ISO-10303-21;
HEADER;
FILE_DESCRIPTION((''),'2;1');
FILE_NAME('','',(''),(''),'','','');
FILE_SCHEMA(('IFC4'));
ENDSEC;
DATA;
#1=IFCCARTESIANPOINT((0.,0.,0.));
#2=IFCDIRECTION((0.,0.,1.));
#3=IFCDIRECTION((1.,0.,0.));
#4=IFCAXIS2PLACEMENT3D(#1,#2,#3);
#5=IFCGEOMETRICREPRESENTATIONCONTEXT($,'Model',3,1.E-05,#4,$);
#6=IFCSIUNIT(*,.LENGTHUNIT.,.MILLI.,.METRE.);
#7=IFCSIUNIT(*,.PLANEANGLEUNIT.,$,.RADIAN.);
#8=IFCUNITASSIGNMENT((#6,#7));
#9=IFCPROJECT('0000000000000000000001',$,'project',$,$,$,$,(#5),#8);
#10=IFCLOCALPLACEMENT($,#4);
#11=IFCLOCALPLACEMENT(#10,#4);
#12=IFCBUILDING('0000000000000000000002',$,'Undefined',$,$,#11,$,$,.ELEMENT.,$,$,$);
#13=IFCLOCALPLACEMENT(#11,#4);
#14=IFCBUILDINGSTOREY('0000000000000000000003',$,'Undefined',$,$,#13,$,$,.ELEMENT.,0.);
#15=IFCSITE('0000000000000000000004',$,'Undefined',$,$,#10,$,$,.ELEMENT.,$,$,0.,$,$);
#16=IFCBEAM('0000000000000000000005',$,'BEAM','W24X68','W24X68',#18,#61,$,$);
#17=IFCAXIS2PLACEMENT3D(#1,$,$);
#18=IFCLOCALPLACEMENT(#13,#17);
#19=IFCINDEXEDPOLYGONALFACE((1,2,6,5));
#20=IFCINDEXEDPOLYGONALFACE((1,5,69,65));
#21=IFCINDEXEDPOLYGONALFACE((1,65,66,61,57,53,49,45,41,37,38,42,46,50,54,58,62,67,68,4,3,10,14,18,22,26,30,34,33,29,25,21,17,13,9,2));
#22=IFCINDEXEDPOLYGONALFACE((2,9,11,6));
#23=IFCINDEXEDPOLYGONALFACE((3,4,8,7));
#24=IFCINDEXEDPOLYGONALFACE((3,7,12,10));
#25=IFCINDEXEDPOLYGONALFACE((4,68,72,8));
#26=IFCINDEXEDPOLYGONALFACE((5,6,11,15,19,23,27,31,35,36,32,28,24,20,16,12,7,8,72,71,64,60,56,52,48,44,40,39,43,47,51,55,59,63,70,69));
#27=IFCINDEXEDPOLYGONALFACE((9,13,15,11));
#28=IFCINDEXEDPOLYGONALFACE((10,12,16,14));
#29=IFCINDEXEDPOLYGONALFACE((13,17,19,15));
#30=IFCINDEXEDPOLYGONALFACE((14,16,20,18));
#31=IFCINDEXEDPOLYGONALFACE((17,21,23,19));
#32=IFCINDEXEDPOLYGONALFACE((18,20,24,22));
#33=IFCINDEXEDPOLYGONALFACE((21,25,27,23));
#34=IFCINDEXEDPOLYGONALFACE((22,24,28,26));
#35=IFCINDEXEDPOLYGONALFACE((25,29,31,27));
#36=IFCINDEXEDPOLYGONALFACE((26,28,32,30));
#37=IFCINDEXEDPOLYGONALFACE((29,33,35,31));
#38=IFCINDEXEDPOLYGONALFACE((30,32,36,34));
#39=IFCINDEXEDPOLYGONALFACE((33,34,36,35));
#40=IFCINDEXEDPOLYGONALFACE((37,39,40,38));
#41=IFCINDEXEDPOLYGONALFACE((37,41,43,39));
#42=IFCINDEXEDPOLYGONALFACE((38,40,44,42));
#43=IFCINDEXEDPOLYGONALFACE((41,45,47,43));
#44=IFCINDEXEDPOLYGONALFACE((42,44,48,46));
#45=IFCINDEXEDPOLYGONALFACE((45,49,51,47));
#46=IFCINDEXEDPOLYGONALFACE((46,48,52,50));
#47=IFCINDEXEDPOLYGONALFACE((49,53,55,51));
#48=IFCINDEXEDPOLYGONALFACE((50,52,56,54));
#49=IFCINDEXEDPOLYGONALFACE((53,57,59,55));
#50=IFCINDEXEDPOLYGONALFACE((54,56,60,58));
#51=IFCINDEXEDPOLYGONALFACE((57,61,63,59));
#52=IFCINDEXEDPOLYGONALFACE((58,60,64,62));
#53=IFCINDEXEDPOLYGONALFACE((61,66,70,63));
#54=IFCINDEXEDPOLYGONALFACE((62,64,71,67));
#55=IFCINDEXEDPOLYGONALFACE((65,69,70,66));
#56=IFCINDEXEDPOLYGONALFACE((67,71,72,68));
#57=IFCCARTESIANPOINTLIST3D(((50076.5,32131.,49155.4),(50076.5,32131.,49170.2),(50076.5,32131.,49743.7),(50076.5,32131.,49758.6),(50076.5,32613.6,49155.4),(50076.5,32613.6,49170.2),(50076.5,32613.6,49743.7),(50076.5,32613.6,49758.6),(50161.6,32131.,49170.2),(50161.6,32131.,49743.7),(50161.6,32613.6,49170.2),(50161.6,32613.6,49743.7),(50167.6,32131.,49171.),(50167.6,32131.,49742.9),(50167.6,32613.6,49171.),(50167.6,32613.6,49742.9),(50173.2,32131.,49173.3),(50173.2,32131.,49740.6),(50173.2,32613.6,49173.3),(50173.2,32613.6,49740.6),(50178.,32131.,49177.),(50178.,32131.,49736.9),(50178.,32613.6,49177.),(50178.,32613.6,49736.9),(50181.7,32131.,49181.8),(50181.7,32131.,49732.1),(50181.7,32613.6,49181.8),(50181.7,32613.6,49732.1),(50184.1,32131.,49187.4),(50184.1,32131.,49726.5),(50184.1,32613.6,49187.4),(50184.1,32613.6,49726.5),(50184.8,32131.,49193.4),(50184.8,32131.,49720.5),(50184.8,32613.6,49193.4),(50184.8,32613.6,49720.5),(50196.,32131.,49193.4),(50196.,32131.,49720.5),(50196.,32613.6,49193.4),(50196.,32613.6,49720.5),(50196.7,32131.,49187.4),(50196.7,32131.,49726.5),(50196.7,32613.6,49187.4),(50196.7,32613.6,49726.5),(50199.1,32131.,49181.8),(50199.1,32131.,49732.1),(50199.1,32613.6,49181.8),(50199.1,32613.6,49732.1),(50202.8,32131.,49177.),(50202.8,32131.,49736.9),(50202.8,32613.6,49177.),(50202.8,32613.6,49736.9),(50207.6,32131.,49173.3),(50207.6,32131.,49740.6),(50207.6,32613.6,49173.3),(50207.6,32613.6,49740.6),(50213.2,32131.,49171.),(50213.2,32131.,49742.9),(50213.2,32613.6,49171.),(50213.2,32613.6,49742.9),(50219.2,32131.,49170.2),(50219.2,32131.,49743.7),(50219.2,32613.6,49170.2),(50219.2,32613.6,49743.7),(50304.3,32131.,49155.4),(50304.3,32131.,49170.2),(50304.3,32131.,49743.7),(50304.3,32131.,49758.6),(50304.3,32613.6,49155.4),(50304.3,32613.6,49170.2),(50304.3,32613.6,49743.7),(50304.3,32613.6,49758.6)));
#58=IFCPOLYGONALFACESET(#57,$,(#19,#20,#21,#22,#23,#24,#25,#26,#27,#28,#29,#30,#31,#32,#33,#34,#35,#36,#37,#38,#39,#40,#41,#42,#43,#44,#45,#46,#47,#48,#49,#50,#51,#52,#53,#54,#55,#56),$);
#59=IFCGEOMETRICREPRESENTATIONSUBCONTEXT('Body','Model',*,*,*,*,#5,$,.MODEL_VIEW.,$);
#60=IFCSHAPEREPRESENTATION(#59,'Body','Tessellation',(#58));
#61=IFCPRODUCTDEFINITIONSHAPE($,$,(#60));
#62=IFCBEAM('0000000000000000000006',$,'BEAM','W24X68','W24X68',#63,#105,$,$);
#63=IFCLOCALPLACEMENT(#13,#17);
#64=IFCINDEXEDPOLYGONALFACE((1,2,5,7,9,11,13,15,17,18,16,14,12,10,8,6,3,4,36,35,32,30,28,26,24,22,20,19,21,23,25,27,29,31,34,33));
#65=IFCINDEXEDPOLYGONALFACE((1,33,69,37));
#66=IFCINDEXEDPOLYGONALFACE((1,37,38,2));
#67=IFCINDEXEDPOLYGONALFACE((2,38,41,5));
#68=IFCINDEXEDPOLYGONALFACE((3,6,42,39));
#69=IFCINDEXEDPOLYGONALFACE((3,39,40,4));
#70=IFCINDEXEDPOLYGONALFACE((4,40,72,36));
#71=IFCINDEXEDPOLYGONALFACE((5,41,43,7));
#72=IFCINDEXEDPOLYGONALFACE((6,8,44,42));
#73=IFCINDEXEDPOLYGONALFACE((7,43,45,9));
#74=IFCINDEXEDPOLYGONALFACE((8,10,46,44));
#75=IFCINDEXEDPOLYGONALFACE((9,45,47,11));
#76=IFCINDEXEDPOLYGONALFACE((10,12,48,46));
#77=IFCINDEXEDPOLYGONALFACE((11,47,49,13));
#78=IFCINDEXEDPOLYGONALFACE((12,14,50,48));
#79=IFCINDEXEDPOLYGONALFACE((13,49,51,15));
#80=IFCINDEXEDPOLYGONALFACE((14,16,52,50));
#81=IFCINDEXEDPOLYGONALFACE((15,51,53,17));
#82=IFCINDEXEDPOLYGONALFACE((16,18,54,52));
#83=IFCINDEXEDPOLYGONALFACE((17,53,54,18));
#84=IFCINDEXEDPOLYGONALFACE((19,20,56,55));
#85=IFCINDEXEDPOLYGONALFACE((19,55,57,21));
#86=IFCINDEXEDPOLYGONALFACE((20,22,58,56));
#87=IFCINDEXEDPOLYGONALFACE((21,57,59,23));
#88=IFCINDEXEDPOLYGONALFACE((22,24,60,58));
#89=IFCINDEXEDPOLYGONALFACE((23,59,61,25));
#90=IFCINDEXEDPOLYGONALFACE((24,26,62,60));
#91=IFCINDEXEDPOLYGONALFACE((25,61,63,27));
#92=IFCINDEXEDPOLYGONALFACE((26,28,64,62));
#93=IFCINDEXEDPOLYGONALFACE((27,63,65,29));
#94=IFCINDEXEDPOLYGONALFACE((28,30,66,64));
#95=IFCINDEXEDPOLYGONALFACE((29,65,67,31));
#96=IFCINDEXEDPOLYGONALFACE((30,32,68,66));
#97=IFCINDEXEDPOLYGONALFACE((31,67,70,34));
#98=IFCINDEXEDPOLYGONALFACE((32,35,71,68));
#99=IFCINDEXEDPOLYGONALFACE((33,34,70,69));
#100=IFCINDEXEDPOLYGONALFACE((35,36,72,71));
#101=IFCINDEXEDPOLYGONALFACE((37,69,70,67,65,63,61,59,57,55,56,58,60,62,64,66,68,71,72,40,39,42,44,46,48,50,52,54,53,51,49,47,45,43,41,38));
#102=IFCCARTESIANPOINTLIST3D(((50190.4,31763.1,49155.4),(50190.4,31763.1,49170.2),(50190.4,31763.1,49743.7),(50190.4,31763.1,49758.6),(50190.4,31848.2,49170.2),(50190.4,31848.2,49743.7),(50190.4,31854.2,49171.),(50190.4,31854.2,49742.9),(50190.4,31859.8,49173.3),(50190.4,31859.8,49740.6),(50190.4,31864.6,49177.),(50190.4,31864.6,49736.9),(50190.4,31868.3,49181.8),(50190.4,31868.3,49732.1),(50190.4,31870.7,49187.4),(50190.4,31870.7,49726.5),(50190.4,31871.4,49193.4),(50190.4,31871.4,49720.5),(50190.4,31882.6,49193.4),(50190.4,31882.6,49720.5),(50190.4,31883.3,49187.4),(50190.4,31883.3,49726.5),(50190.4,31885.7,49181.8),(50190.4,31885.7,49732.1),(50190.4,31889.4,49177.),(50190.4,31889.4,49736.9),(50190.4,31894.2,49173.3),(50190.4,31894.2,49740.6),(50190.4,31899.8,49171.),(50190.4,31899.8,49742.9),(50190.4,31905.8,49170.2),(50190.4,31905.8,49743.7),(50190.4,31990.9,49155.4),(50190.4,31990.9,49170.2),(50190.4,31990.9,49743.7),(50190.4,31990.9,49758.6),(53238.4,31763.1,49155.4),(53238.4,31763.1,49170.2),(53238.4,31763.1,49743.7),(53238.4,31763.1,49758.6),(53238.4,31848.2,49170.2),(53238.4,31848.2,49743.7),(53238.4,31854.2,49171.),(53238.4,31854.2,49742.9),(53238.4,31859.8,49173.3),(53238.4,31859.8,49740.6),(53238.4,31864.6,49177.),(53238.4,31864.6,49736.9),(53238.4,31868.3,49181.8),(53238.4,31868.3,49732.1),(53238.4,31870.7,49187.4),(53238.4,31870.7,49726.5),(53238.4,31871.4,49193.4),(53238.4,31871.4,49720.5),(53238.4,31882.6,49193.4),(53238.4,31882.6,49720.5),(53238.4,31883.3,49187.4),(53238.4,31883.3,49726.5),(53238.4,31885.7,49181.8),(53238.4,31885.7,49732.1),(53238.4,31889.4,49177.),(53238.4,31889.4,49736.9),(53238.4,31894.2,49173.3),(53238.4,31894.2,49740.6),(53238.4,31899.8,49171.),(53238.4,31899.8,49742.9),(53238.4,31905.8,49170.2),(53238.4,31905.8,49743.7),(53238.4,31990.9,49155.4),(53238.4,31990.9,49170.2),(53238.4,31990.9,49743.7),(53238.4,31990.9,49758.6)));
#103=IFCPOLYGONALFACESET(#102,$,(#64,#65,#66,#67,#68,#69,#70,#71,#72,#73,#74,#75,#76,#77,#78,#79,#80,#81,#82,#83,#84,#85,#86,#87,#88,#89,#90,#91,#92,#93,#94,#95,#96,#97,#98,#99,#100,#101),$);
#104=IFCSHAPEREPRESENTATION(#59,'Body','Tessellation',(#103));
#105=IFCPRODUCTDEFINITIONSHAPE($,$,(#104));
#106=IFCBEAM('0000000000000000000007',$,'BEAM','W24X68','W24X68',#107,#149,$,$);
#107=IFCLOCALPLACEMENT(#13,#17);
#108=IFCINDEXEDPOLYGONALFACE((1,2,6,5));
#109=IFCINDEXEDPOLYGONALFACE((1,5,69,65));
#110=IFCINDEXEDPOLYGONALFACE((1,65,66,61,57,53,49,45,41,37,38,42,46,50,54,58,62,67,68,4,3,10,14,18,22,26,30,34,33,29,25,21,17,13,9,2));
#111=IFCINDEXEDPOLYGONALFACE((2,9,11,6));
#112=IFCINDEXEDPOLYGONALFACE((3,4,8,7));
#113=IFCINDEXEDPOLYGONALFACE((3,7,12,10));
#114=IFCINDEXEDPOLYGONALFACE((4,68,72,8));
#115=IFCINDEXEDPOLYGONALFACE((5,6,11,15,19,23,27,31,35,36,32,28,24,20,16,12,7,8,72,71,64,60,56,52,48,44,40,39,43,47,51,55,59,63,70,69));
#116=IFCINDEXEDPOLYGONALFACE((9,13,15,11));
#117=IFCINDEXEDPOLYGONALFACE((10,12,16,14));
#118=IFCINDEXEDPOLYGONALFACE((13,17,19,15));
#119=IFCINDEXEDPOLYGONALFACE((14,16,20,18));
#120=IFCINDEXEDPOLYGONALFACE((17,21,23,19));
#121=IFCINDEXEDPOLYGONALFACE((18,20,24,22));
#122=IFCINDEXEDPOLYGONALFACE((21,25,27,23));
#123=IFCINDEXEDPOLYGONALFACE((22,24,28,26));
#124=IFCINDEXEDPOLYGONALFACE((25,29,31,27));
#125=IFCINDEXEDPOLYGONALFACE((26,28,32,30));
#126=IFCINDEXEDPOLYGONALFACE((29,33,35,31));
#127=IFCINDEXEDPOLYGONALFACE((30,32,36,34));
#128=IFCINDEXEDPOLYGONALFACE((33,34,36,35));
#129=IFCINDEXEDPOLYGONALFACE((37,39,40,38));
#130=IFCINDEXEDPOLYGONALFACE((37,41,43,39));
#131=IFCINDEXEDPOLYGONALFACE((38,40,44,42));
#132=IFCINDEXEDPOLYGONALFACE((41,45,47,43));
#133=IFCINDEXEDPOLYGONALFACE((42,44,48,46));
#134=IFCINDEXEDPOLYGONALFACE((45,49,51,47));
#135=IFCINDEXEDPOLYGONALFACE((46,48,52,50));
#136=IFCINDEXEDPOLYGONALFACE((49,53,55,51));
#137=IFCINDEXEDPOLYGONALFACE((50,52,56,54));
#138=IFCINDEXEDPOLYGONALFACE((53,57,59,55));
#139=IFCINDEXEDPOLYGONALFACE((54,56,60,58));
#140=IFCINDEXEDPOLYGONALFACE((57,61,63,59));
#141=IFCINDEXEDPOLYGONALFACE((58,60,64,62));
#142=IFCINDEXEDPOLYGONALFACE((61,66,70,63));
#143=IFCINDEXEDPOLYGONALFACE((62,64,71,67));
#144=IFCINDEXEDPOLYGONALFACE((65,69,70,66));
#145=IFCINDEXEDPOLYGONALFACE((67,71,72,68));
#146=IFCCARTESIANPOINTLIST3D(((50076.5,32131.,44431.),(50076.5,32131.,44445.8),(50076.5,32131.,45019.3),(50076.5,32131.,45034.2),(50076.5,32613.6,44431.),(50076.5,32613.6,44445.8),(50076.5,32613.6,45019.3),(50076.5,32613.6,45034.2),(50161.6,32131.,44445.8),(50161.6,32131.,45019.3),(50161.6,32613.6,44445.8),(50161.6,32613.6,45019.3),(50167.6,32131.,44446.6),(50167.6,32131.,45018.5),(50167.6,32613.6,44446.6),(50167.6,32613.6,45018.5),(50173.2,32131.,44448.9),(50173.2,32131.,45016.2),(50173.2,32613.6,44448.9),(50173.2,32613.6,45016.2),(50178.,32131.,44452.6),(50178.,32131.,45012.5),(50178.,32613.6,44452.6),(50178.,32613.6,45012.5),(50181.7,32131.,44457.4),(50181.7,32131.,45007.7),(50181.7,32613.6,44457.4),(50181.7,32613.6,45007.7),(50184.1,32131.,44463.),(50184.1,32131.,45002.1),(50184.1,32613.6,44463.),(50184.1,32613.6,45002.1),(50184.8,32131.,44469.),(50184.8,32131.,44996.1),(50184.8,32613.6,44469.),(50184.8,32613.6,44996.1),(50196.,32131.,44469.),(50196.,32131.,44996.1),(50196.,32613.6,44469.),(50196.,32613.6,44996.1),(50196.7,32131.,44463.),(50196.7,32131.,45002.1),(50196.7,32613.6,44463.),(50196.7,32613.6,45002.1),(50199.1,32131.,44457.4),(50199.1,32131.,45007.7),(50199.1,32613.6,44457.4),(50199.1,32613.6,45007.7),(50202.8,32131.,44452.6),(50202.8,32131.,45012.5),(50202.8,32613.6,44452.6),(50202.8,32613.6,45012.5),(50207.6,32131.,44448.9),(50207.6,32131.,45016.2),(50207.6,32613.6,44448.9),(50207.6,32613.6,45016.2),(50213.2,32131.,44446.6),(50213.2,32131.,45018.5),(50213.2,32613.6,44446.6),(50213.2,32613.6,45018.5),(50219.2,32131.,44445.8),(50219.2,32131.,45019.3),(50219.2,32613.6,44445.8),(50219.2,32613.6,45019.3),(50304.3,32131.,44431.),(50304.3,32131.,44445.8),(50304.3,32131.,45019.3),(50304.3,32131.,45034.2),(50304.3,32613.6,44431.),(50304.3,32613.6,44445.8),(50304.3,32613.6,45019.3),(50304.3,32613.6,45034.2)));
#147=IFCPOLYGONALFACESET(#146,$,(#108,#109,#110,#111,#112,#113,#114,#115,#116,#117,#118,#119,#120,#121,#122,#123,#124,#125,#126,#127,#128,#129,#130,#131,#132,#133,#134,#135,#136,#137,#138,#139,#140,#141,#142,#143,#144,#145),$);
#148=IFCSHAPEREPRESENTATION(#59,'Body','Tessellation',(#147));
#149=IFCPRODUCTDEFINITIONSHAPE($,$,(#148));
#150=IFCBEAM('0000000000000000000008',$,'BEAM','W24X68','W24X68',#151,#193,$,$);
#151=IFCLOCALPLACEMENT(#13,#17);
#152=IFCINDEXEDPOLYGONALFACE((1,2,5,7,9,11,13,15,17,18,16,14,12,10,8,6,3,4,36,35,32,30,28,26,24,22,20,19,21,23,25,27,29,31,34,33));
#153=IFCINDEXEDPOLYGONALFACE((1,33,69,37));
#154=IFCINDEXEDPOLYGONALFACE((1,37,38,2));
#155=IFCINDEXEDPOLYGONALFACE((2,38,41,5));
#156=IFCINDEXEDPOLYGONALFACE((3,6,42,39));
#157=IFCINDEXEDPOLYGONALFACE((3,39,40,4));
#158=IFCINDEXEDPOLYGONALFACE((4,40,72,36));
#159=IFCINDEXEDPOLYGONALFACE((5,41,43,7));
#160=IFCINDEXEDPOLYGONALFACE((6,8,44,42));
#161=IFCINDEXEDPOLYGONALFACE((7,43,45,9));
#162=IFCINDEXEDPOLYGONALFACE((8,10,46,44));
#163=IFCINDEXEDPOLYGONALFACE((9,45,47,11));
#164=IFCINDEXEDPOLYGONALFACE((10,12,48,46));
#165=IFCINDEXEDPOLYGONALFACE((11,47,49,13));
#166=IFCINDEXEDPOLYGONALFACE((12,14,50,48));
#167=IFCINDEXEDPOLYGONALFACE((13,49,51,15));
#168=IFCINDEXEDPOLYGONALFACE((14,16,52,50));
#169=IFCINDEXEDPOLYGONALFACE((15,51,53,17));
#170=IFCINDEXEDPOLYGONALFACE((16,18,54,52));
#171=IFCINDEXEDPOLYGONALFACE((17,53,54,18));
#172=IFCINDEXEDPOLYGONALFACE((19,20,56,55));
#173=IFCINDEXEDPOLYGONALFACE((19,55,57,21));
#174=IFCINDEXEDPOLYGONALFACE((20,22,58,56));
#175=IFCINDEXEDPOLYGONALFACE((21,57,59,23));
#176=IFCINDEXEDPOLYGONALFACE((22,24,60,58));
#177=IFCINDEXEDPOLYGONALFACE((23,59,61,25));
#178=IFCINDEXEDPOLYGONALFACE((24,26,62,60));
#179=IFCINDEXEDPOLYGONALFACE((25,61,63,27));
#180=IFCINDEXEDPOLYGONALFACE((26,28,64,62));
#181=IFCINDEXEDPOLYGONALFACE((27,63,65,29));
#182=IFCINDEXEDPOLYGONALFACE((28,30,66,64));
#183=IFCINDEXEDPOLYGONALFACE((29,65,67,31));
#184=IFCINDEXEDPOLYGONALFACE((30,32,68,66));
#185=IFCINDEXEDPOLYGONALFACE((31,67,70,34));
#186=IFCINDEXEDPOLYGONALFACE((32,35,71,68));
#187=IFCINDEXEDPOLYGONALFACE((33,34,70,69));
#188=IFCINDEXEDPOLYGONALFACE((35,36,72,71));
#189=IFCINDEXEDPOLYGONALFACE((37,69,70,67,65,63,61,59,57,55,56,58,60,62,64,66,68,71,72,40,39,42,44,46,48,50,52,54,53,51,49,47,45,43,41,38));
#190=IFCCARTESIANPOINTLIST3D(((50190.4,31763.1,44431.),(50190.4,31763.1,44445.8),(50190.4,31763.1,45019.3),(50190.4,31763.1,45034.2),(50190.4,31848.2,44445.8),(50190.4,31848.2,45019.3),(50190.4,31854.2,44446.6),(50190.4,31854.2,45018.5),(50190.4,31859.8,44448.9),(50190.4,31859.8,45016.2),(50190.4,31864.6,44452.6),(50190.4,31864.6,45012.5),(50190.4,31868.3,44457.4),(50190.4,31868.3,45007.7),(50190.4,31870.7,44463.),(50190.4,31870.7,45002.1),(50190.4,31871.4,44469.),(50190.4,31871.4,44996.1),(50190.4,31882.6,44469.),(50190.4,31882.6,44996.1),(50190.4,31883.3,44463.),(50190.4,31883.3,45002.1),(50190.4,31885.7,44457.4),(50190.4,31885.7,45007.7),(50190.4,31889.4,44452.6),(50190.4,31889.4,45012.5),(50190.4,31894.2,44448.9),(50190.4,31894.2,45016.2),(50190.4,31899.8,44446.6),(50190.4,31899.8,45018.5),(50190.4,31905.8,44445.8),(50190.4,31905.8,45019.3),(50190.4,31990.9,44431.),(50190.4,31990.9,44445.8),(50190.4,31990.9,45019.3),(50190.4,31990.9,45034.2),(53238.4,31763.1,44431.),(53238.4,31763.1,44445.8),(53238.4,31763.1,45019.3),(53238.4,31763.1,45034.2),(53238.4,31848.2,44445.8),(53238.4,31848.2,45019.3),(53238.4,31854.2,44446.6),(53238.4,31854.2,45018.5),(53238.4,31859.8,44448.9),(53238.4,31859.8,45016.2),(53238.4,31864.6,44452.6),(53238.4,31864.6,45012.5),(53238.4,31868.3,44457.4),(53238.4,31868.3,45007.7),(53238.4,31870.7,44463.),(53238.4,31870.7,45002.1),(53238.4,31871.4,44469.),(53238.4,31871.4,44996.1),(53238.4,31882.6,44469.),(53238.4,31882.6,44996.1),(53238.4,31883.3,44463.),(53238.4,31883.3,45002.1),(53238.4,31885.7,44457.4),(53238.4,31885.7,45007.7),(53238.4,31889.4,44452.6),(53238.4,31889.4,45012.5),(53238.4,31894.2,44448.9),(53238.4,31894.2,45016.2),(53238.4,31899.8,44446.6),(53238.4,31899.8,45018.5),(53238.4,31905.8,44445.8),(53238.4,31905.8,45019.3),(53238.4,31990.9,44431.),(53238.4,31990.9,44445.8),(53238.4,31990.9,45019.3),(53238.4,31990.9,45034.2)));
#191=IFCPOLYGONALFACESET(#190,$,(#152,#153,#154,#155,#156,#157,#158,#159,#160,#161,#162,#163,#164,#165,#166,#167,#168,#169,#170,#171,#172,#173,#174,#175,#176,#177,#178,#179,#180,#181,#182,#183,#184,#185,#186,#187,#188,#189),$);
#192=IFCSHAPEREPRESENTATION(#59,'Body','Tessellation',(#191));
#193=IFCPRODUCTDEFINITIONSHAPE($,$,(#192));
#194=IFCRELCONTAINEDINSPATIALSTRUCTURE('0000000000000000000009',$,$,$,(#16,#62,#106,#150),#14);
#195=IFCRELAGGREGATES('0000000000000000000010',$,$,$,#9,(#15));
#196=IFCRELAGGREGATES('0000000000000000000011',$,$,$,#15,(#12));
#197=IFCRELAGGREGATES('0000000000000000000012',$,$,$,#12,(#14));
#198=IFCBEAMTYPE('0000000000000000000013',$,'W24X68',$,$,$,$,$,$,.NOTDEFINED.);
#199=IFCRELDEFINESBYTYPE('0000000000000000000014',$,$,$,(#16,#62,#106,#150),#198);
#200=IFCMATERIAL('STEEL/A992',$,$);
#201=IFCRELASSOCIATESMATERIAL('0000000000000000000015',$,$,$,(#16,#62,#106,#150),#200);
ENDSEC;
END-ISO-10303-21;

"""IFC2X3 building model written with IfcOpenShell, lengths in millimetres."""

from ifc_helpers import new_model, si_unit, frame, origin_with_axes, origin_2d_with_axis, place, context, subcontext, project, spatial, i_section, extrude, material, type_object, element, save


model = new_model("IFC2X3")

# Units and contexts
model_context = context("Model", 3, precision=1e-05, world=origin_with_axes())
body_context = subcontext(model_context, "Body", "Model", "MODEL_VIEW")
ifc_project = project(units=[si_unit("LENGTHUNIT", "METRE", prefix="MILLI"), si_unit("PLANEANGLEUNIT", "RADIAN")], contexts=[model_context])

# Site, building, storey
site_placement = place(None, origin_with_axes())
site = spatial("IfcSite", under=ifc_project, at=site_placement, Name="Undefined", CompositionType="ELEMENT", RefElevation=0.0)
building_placement = place(site_placement, origin_with_axes())
building = spatial("IfcBuilding", under=site, at=building_placement, Name="Undefined", CompositionType="ELEMENT")
storey_placement = place(building_placement, origin_with_axes())
storey = spatial("IfcBuildingStorey", under=building, at=storey_placement, Name="Undefined", CompositionType="ELEMENT", Elevation=0.0)

# Shared definitions
ifc_material = material(Name="STEEL/A992")

# Beams
beam_type_1 = type_object("IfcBeamType", Name="W24X68", PredefinedType="NOTDEFINED")
beam_1_placement = place(storey_placement, frame((50190.4, 32131.0, 49457.0), z_axis=(0.0, 0.0, 1.0), x_axis=(0.0, 1.0, 0.0)))
element("IfcBeam", 1, at=beam_1_placement, inside=storey, type_object=beam_type_1, material=ifc_material, Name="BEAM", Description="W24X68", ObjectType="W24X68", context=body_context, shape_type="SweptSolid", body=[
    extrude(i_section(OverallWidth=227.8, OverallDepth=603.2, WebThickness=11.1, FlangeThickness=14.9, FilletRadius=23.2, at=origin_2d_with_axis()), frame((482.6, 0.0, 0.0), z_axis=(-1.0, 0.0, 0.0), x_axis=(0.0, -1.0, 0.0)), (0.0, 0.0, 1.0), 482.6),
])
beam_2_placement = place(storey_placement, frame((50190.4, 31877.0, 49457.0), z_axis=(0.0, 0.0, 1.0), x_axis=(1.0, 0.0, 0.0)))
element("IfcBeam", 2, at=beam_2_placement, inside=storey, type_object=beam_type_1, material=ifc_material, Name="BEAM", Description="W24X68", ObjectType="W24X68", context=body_context, shape_type="SweptSolid", body=[
    extrude(i_section(OverallWidth=227.8, OverallDepth=603.2, WebThickness=11.1, FlangeThickness=14.9, FilletRadius=23.2, at=origin_2d_with_axis()), frame((3048.0, 0.0, 0.0), z_axis=(-1.0, 0.0, 0.0), x_axis=(0.0, -1.0, 0.0)), (0.0, 0.0, 1.0), 3048.0),
])
beam_3_placement = place(storey_placement, frame((50190.4, 32131.0, 44732.6), z_axis=(0.0, 0.0, 1.0), x_axis=(0.0, 1.0, 0.0)))
element("IfcBeam", 3, at=beam_3_placement, inside=storey, type_object=beam_type_1, material=ifc_material, Name="BEAM", Description="W24X68", ObjectType="W24X68", context=body_context, shape_type="SweptSolid", body=[
    extrude(i_section(OverallWidth=227.8, OverallDepth=603.2, WebThickness=11.1, FlangeThickness=14.9, FilletRadius=23.2, at=origin_2d_with_axis()), frame((482.6, 0.0, 0.0), z_axis=(-1.0, 0.0, 0.0), x_axis=(0.0, -1.0, 0.0)), (0.0, 0.0, 1.0), 482.6),
])
beam_4_placement = place(storey_placement, frame((50190.4, 31877.0, 44732.6), z_axis=(0.0, 0.0, 1.0), x_axis=(1.0, 0.0, 0.0)))
element("IfcBeam", 4, at=beam_4_placement, inside=storey, type_object=beam_type_1, material=ifc_material, Name="BEAM", Description="W24X68", ObjectType="W24X68", context=body_context, shape_type="SweptSolid", body=[
    extrude(i_section(OverallWidth=227.8, OverallDepth=603.2, WebThickness=11.1, FlangeThickness=14.9, FilletRadius=23.2, at=origin_2d_with_axis()), frame((3048.0, 0.0, 0.0), z_axis=(-1.0, 0.0, 0.0), x_axis=(0.0, -1.0, 0.0)), (0.0, 0.0, 1.0), 3048.0),
])

save(model, "model.ifc")
